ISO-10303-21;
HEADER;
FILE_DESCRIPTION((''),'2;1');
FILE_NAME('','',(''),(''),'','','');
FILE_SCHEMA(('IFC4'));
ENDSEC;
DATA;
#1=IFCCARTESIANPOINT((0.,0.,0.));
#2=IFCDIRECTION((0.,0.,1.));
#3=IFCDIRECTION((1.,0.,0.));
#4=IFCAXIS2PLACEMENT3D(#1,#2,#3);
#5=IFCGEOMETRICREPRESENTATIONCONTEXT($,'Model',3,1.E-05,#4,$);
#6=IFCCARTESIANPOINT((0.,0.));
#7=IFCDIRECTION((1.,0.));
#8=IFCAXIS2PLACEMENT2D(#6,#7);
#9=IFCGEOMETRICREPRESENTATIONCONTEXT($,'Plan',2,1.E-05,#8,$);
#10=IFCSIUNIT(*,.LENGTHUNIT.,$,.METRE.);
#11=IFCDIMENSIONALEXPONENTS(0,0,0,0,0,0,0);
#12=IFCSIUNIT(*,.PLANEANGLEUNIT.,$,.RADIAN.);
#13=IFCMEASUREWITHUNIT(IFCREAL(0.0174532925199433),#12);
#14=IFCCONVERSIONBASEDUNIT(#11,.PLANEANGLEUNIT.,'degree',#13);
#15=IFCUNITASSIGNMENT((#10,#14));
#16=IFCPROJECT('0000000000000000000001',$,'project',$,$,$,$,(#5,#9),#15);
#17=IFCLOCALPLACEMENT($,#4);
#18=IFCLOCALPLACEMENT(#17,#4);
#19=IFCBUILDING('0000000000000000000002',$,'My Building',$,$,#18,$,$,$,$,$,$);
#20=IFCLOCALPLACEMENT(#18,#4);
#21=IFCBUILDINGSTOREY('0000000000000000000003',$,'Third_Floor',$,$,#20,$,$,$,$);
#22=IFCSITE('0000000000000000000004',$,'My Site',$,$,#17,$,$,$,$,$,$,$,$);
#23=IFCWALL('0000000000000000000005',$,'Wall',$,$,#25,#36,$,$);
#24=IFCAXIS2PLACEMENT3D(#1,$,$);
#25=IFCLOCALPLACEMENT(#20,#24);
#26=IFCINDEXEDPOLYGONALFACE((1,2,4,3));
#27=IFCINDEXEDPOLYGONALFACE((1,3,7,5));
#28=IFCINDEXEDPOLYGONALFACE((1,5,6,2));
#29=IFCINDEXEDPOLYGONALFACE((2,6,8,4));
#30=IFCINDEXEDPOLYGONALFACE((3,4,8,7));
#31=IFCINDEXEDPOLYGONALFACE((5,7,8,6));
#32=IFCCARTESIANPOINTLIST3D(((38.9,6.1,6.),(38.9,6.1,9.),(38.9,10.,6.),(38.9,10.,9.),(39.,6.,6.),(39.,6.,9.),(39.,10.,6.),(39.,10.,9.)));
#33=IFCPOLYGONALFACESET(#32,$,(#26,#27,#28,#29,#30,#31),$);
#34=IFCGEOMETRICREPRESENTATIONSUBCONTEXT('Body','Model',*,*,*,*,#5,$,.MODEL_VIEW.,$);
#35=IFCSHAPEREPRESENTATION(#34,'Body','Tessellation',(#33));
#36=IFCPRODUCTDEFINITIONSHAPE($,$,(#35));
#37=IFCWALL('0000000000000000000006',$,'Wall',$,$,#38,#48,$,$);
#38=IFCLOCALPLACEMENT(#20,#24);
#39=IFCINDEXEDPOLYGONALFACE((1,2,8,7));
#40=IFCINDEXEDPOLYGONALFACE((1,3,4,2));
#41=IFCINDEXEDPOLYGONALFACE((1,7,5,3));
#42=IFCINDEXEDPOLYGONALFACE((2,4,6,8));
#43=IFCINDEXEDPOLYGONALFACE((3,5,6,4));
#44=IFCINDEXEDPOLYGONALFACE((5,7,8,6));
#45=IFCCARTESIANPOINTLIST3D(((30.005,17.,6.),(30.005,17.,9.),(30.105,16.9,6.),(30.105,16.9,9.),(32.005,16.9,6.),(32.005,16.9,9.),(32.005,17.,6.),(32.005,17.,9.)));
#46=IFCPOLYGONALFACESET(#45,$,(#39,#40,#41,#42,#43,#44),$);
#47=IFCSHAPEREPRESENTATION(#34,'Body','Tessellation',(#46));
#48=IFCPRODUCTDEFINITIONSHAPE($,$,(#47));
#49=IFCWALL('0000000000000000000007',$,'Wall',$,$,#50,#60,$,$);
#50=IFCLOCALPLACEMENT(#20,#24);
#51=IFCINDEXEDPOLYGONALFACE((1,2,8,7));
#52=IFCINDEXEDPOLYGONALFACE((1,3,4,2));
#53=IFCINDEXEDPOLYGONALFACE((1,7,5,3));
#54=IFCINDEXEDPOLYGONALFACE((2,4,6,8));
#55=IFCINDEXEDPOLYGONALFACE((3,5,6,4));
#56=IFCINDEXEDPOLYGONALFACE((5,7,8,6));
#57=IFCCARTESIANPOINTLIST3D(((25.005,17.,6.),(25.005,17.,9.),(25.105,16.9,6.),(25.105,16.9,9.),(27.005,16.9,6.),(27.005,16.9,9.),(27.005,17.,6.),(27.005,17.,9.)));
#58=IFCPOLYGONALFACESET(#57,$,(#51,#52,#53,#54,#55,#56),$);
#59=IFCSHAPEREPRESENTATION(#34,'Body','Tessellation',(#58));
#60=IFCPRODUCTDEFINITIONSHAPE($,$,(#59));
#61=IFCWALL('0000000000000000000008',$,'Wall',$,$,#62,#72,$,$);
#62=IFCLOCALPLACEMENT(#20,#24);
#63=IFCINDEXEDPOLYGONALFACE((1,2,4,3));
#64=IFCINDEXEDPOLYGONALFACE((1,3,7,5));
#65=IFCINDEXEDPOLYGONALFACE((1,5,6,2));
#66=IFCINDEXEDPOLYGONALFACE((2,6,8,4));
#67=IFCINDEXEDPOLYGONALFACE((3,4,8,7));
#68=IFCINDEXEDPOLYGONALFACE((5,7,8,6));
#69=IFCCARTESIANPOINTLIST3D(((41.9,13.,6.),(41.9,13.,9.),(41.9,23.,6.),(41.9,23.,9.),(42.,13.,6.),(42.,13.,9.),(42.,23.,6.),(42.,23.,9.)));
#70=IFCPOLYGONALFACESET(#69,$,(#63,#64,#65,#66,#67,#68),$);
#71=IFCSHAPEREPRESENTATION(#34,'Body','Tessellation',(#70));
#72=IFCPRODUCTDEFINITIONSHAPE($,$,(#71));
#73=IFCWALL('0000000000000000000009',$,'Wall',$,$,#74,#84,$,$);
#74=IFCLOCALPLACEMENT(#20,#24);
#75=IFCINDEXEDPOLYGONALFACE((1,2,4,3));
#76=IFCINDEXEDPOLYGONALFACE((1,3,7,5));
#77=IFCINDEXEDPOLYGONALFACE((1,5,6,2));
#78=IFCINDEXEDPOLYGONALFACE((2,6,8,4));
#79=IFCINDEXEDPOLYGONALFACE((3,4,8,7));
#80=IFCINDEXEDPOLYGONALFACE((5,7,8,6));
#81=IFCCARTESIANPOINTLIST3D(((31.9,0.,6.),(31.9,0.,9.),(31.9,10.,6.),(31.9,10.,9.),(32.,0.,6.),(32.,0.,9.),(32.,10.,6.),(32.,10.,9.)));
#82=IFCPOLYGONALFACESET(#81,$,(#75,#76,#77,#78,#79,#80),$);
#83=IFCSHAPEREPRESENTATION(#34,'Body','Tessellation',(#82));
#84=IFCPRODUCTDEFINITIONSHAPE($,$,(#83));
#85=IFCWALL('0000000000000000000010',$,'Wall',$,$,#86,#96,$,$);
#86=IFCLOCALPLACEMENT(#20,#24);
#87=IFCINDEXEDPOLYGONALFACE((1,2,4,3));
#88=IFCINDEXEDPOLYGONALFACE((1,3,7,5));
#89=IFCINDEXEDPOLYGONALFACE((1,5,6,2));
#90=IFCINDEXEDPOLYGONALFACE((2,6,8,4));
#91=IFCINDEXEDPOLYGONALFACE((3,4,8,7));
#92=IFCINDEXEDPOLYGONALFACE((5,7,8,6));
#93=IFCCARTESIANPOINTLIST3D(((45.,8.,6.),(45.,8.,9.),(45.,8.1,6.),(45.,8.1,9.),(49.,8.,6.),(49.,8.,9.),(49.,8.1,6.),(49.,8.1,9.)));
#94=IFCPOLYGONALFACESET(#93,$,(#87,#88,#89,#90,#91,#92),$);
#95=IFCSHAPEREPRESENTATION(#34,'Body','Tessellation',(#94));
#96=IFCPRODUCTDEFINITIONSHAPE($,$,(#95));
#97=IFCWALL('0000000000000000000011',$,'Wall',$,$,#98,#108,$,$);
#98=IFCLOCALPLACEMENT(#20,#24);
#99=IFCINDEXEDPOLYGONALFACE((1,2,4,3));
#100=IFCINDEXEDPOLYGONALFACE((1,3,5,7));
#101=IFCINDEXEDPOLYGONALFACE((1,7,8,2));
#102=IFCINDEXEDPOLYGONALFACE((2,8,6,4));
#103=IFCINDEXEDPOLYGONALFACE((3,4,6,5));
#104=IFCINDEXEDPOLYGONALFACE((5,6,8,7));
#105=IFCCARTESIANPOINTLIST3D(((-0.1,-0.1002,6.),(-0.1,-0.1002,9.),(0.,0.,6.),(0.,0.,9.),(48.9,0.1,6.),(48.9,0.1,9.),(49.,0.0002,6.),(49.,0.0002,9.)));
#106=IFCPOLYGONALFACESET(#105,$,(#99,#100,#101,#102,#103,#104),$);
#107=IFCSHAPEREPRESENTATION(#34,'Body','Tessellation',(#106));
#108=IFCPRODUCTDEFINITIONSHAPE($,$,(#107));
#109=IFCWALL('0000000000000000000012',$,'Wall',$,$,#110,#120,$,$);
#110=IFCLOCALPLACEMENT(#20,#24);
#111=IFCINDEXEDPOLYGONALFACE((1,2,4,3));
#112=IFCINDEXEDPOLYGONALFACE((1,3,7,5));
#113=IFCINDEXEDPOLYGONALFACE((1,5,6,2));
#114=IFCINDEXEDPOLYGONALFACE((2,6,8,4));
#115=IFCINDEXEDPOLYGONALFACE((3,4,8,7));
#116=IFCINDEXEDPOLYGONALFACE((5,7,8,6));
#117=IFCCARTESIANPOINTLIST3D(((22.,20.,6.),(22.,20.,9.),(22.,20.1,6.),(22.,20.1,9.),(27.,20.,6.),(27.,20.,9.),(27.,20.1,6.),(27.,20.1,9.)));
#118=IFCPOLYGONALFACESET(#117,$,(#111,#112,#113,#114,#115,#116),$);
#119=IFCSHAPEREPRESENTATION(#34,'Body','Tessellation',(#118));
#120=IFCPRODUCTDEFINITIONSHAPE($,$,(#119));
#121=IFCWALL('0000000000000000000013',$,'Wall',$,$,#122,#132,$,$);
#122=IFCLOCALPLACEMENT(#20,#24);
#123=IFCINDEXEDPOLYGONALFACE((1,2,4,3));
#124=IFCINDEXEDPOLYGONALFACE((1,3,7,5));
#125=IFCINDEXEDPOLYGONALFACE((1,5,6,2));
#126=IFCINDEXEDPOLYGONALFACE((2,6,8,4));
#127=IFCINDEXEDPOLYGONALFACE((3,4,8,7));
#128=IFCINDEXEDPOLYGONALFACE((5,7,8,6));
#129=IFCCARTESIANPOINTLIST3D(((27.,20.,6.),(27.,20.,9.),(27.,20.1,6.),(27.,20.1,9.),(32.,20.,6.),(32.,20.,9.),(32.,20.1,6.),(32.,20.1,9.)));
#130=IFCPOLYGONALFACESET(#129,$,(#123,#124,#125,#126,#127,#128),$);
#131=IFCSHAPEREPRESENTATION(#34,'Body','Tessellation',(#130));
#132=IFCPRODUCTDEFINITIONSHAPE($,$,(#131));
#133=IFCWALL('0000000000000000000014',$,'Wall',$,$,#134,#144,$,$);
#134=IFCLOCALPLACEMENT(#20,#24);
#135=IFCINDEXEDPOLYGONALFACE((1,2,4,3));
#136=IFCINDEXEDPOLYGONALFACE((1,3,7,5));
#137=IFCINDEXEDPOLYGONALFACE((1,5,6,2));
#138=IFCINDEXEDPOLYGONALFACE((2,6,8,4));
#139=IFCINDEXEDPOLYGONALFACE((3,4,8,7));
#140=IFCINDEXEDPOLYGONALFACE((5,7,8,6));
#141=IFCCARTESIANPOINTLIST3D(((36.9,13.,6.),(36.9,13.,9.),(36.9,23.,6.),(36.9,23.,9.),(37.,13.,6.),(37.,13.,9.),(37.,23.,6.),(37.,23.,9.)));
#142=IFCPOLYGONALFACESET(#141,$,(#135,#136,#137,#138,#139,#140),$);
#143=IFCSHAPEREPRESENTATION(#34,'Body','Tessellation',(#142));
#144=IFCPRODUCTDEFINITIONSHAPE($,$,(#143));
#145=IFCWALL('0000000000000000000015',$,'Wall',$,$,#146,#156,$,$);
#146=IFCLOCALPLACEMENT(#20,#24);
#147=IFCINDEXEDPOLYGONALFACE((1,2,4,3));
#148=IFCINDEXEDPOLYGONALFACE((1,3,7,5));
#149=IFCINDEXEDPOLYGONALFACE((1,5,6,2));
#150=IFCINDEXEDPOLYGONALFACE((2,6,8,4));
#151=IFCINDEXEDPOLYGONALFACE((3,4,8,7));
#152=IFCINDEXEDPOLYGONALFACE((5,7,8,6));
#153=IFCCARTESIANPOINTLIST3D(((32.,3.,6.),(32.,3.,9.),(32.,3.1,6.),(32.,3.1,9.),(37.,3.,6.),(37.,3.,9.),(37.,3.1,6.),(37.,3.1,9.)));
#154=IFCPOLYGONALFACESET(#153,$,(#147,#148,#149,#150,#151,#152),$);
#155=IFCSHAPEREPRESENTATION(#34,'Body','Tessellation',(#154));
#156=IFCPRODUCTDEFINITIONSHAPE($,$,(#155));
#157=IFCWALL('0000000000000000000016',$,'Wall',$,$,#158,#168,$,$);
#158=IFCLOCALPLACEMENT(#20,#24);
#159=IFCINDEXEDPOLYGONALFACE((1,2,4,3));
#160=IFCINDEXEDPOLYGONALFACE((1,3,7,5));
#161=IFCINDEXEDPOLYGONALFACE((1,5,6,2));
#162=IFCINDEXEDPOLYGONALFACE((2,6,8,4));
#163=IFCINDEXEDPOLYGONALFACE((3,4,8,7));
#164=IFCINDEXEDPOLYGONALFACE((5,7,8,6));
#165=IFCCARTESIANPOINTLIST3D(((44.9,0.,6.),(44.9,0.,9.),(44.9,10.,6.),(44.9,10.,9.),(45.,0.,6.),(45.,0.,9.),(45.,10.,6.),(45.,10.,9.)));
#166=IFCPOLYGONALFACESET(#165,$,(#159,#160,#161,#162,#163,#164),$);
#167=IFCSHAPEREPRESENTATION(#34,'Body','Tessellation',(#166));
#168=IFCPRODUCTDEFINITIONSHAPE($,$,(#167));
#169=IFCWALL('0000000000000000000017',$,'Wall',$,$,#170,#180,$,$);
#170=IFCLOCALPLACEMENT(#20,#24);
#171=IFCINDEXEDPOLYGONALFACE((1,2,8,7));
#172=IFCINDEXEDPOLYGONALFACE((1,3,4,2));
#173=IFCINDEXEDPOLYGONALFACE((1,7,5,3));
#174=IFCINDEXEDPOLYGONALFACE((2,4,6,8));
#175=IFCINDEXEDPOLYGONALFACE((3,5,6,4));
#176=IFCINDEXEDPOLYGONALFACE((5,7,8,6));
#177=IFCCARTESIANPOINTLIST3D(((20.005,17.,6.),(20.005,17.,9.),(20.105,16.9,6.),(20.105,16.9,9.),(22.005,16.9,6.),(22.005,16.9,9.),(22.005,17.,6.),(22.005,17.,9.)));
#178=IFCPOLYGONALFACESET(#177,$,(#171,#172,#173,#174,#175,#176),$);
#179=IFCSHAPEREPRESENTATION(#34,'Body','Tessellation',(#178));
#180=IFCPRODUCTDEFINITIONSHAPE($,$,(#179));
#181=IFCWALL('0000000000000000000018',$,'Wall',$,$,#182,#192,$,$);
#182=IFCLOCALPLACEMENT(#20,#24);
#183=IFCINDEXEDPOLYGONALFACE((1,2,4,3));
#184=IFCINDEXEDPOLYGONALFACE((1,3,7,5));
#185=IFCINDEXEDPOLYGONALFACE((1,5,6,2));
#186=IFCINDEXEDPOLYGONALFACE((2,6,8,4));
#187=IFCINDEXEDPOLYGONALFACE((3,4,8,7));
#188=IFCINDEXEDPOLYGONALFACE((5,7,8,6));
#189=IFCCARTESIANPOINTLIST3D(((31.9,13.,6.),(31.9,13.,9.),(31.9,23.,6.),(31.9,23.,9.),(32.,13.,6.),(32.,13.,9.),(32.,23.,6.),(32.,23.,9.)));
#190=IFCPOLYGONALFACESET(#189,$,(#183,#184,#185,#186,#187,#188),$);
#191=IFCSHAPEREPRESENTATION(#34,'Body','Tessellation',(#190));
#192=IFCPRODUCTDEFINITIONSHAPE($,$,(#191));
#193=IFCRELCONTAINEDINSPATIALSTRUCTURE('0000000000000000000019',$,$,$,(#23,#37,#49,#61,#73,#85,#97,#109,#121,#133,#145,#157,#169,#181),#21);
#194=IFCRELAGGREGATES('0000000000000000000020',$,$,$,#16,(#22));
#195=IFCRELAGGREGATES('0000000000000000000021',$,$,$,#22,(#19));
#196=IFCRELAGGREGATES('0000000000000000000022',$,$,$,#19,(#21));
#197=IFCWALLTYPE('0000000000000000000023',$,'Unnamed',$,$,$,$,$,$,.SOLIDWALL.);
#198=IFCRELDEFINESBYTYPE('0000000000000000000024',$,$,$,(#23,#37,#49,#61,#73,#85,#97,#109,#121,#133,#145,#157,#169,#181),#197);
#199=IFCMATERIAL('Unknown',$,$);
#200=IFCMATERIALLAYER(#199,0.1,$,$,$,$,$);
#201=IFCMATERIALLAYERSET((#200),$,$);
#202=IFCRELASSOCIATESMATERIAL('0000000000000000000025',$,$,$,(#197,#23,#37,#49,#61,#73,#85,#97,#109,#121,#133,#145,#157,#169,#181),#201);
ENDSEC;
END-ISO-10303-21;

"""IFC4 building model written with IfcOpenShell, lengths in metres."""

from ifc_helpers import new_model, entity, si_unit, converted_unit, frame, origin_with_axes, origin_2d_with_axis, place, context, subcontext, project, spatial, line, indexed_curve, outline, extrude, material, layer, layer_set, layer_usage, type_object, element, save


model = new_model("IFC4")

# Units and contexts
model_context = context("Model", 3, precision=1e-05, world=origin_with_axes())
plan_context = context("Plan", 2, precision=1e-05, world=origin_2d_with_axis())
body_context = subcontext(model_context, "Body", "Model", "MODEL_VIEW")
ifc_project = project(units=[si_unit("LENGTHUNIT", "METRE"), converted_unit("PLANEANGLEUNIT", "degree", entity("IfcReal", 0.0174532925199433), si_unit("PLANEANGLEUNIT", "RADIAN"), dimensions=[0, 0, 0, 0, 0, 0, 0])], contexts=[model_context, plan_context])

# Site, building, storey
site_placement = place(None, origin_with_axes())
site = spatial("IfcSite", under=ifc_project, at=site_placement, Name="My Site")
building_placement = place(site_placement, origin_with_axes())
building = spatial("IfcBuilding", under=site, at=building_placement, Name="My Building")
storey_placement = place(building_placement, origin_with_axes())
storey = spatial("IfcBuildingStorey", under=building, at=storey_placement, Name="Third_Floor")

# Walls
ifc_material = material(Name="Unknown")
ifc_layer = layer(ifc_material, 0.1)
ifc_layer_set = layer_set([ifc_layer])
ifc_layer_usage_1 = layer_usage(ifc_layer_set, "AXIS2", "POSITIVE", 0.0)
wall_type = type_object("IfcWallType", Name="Unnamed", PredefinedType="SOLIDWALL", material=ifc_layer_set)
wall_1_placement = place(storey_placement, frame((39.0, 6.0, 6.0), z_axis=(0.0, 0.0, 1.0), x_axis=(0.0, 1.0, 0.0)))
element("IfcWall", 1, at=wall_1_placement, inside=storey, type_object=wall_type, material=ifc_layer_usage_1, Name="Wall", context=body_context, shape_type="SweptSolid", body=[
    extrude(outline(indexed_curve([(0.0, 0.0), (0.1, 0.1), (4.0, 0.1), (4.0, 0.0)], segments=[line(1, 2, 3, 4, 1)])), origin_with_axes(), (0.0, 0.0, 1.0), 3.0),
])
ifc_layer_usage_2 = layer_usage(ifc_layer_set, "AXIS2", "POSITIVE", 0.0)
wall_2_placement = place(storey_placement, frame((32.005, 17.0, 6.0), z_axis=(0.0, 0.0, 1.0), x_axis=(-1.0, 0.0, 0.0)))
element("IfcWall", 2, at=wall_2_placement, inside=storey, type_object=wall_type, material=ifc_layer_usage_2, Name="Wall", context=body_context, shape_type="SweptSolid", body=[
    extrude(outline(indexed_curve([(0.0, 0.0), (0.0, 0.1), (1.9, 0.1), (2.0, 0.0)], segments=[line(1, 2, 3, 4, 1)])), origin_with_axes(), (0.0, 0.0, 1.0), 3.0),
])
ifc_layer_usage_3 = layer_usage(ifc_layer_set, "AXIS2", "POSITIVE", 0.0)
wall_3_placement = place(storey_placement, frame((27.005, 17.0, 6.0), z_axis=(0.0, 0.0, 1.0), x_axis=(-1.0, 0.0, 0.0)))
element("IfcWall", 3, at=wall_3_placement, inside=storey, type_object=wall_type, material=ifc_layer_usage_3, Name="Wall", context=body_context, shape_type="SweptSolid", body=[
    extrude(outline(indexed_curve([(0.0, 0.0), (0.0, 0.1), (1.9, 0.1), (2.0, 0.0)], segments=[line(1, 2, 3, 4, 1)])), origin_with_axes(), (0.0, 0.0, 1.0), 3.0),
])
ifc_layer_usage_4 = layer_usage(ifc_layer_set, "AXIS2", "POSITIVE", 0.0)
wall_4_placement = place(storey_placement, frame((41.9, 23.0, 6.0), z_axis=(0.0, 0.0, 1.0), x_axis=(0.0, -1.0, 0.0)))
element("IfcWall", 4, at=wall_4_placement, inside=storey, type_object=wall_type, material=ifc_layer_usage_4, Name="Wall", context=body_context, shape_type="SweptSolid", body=[
    extrude(outline(indexed_curve([(0.0, 0.0), (0.0, 0.1), (10.0, 0.1), (10.0, 0.0)], segments=[line(1, 2, 3, 4, 1)])), origin_with_axes(), (0.0, 0.0, 1.0), 3.0),
])
ifc_layer_usage_5 = layer_usage(ifc_layer_set, "AXIS2", "POSITIVE", 0.0)
wall_5_placement = place(storey_placement, frame((31.9, 10.0, 6.0), z_axis=(0.0, 0.0, 1.0), x_axis=(0.0, -1.0, 0.0)))
element("IfcWall", 5, at=wall_5_placement, inside=storey, type_object=wall_type, material=ifc_layer_usage_5, Name="Wall", context=body_context, shape_type="SweptSolid", body=[
    extrude(outline(indexed_curve([(0.0, 0.0), (0.0, 0.1), (10.0, 0.1), (10.0, 0.0)], segments=[line(1, 2, 3, 4, 1)])), origin_with_axes(), (0.0, 0.0, 1.0), 3.0),
])
ifc_layer_usage_6 = layer_usage(ifc_layer_set, "AXIS2", "POSITIVE", 0.0)
wall_6_placement = place(storey_placement, frame((45.0, 8.0, 6.0), z_axis=(0.0, 0.0, 1.0), x_axis=(1.0, 0.0, 0.0)))
element("IfcWall", 6, at=wall_6_placement, inside=storey, type_object=wall_type, material=ifc_layer_usage_6, Name="Wall", context=body_context, shape_type="SweptSolid", body=[
    extrude(outline(indexed_curve([(0.0, 0.0), (0.0, 0.1), (4.0, 0.1), (4.0, 0.0)], segments=[line(1, 2, 3, 4, 1)])), origin_with_axes(), (0.0, 0.0, 1.0), 3.0),
])
ifc_layer_usage_7 = layer_usage(ifc_layer_set, "AXIS2", "POSITIVE", 0.0)
wall_7_placement = place(storey_placement, frame((48.9, 0.1, 6.0), z_axis=(0.0, 0.0, 1.0), x_axis=(-0.999998, -0.002045, 0.0)))
element("IfcWall", 7, at=wall_7_placement, inside=storey, type_object=wall_type, material=ifc_layer_usage_7, Name="Wall", context=body_context, shape_type="SweptSolid", body=[
    extrude(outline(indexed_curve([(0.0, 0.0), (-0.0998, 0.1), (49.0003, 0.1), (48.9001, 0.0)], segments=[line(1, 2, 3, 4, 1)])), origin_with_axes(), (0.0, 0.0, 1.0), 3.0),
])
ifc_layer_usage_8 = layer_usage(ifc_layer_set, "AXIS2", "POSITIVE", 0.0)
wall_8_placement = place(storey_placement, frame((22.0, 20.0, 6.0), z_axis=(0.0, 0.0, 1.0), x_axis=(1.0, 0.0, 0.0)))
element("IfcWall", 8, at=wall_8_placement, inside=storey, type_object=wall_type, material=ifc_layer_usage_8, Name="Wall", context=body_context, shape_type="SweptSolid", body=[
    extrude(outline(indexed_curve([(0.0, 0.0), (0.0, 0.1), (5.0, 0.1), (5.0, 0.0)], segments=[line(1, 2, 3, 4, 1)])), origin_with_axes(), (0.0, 0.0, 1.0), 3.0),
])
ifc_layer_usage_9 = layer_usage(ifc_layer_set, "AXIS2", "POSITIVE", 0.0)
wall_9_placement = place(storey_placement, frame((27.0, 20.0, 6.0), z_axis=(0.0, 0.0, 1.0), x_axis=(1.0, 0.0, 0.0)))
element("IfcWall", 9, at=wall_9_placement, inside=storey, type_object=wall_type, material=ifc_layer_usage_9, Name="Wall", context=body_context, shape_type="SweptSolid", body=[
    extrude(outline(indexed_curve([(0.0, 0.0), (0.0, 0.1), (5.0, 0.1), (5.0, 0.0)], segments=[line(1, 2, 3, 4, 1)])), origin_with_axes(), (0.0, 0.0, 1.0), 3.0),
])
ifc_layer_usage_10 = layer_usage(ifc_layer_set, "AXIS2", "POSITIVE", 0.0)
wall_10_placement = place(storey_placement, frame((36.9, 23.0, 6.0), z_axis=(0.0, 0.0, 1.0), x_axis=(0.0, -1.0, 0.0)))
element("IfcWall", 10, at=wall_10_placement, inside=storey, type_object=wall_type, material=ifc_layer_usage_10, Name="Wall", context=body_context, shape_type="SweptSolid", body=[
    extrude(outline(indexed_curve([(0.0, 0.0), (0.0, 0.1), (10.0, 0.1), (10.0, 0.0)], segments=[line(1, 2, 3, 4, 1)])), origin_with_axes(), (0.0, 0.0, 1.0), 3.0),
])
ifc_layer_usage_11 = layer_usage(ifc_layer_set, "AXIS2", "POSITIVE", 0.0)
wall_11_placement = place(storey_placement, frame((32.0, 3.0, 6.0), z_axis=(0.0, 0.0, 1.0), x_axis=(1.0, 0.0, 0.0)))
element("IfcWall", 11, at=wall_11_placement, inside=storey, type_object=wall_type, material=ifc_layer_usage_11, Name="Wall", context=body_context, shape_type="SweptSolid", body=[
    extrude(outline(indexed_curve([(0.0, 0.0), (0.0, 0.1), (5.0, 0.1), (5.0, 0.0)], segments=[line(1, 2, 3, 4, 1)])), origin_with_axes(), (0.0, 0.0, 1.0), 3.0),
])
ifc_layer_usage_12 = layer_usage(ifc_layer_set, "AXIS2", "POSITIVE", 0.0)
wall_12_placement = place(storey_placement, frame((44.9, 10.0, 6.0), z_axis=(0.0, 0.0, 1.0), x_axis=(0.0, -1.0, 0.0)))
element("IfcWall", 12, at=wall_12_placement, inside=storey, type_object=wall_type, material=ifc_layer_usage_12, Name="Wall", context=body_context, shape_type="SweptSolid", body=[
    extrude(outline(indexed_curve([(0.0, 0.0), (0.0, 0.1), (10.0, 0.1), (10.0, 0.0)], segments=[line(1, 2, 3, 4, 1)])), origin_with_axes(), (0.0, 0.0, 1.0), 3.0),
])
ifc_layer_usage_13 = layer_usage(ifc_layer_set, "AXIS2", "POSITIVE", 0.0)
wall_13_placement = place(storey_placement, frame((22.005, 17.0, 6.0), z_axis=(0.0, 0.0, 1.0), x_axis=(-1.0, 0.0, 0.0)))
element("IfcWall", 13, at=wall_13_placement, inside=storey, type_object=wall_type, material=ifc_layer_usage_13, Name="Wall", context=body_context, shape_type="SweptSolid", body=[
    extrude(outline(indexed_curve([(0.0, 0.0), (0.0, 0.1), (1.9, 0.1), (2.0, 0.0)], segments=[line(1, 2, 3, 4, 1)])), origin_with_axes(), (0.0, 0.0, 1.0), 3.0),
])
ifc_layer_usage_14 = layer_usage(ifc_layer_set, "AXIS2", "POSITIVE", 0.0)
wall_14_placement = place(storey_placement, frame((31.9, 23.0, 6.0), z_axis=(0.0, 0.0, 1.0), x_axis=(0.0, -1.0, 0.0)))
element("IfcWall", 14, at=wall_14_placement, inside=storey, type_object=wall_type, material=ifc_layer_usage_14, Name="Wall", context=body_context, shape_type="SweptSolid", body=[
    extrude(outline(indexed_curve([(0.0, 0.0), (0.0, 0.1), (10.0, 0.1), (10.0, 0.0)], segments=[line(1, 2, 3, 4, 1)])), origin_with_axes(), (0.0, 0.0, 1.0), 3.0),
])

save(model, "model.ifc")
